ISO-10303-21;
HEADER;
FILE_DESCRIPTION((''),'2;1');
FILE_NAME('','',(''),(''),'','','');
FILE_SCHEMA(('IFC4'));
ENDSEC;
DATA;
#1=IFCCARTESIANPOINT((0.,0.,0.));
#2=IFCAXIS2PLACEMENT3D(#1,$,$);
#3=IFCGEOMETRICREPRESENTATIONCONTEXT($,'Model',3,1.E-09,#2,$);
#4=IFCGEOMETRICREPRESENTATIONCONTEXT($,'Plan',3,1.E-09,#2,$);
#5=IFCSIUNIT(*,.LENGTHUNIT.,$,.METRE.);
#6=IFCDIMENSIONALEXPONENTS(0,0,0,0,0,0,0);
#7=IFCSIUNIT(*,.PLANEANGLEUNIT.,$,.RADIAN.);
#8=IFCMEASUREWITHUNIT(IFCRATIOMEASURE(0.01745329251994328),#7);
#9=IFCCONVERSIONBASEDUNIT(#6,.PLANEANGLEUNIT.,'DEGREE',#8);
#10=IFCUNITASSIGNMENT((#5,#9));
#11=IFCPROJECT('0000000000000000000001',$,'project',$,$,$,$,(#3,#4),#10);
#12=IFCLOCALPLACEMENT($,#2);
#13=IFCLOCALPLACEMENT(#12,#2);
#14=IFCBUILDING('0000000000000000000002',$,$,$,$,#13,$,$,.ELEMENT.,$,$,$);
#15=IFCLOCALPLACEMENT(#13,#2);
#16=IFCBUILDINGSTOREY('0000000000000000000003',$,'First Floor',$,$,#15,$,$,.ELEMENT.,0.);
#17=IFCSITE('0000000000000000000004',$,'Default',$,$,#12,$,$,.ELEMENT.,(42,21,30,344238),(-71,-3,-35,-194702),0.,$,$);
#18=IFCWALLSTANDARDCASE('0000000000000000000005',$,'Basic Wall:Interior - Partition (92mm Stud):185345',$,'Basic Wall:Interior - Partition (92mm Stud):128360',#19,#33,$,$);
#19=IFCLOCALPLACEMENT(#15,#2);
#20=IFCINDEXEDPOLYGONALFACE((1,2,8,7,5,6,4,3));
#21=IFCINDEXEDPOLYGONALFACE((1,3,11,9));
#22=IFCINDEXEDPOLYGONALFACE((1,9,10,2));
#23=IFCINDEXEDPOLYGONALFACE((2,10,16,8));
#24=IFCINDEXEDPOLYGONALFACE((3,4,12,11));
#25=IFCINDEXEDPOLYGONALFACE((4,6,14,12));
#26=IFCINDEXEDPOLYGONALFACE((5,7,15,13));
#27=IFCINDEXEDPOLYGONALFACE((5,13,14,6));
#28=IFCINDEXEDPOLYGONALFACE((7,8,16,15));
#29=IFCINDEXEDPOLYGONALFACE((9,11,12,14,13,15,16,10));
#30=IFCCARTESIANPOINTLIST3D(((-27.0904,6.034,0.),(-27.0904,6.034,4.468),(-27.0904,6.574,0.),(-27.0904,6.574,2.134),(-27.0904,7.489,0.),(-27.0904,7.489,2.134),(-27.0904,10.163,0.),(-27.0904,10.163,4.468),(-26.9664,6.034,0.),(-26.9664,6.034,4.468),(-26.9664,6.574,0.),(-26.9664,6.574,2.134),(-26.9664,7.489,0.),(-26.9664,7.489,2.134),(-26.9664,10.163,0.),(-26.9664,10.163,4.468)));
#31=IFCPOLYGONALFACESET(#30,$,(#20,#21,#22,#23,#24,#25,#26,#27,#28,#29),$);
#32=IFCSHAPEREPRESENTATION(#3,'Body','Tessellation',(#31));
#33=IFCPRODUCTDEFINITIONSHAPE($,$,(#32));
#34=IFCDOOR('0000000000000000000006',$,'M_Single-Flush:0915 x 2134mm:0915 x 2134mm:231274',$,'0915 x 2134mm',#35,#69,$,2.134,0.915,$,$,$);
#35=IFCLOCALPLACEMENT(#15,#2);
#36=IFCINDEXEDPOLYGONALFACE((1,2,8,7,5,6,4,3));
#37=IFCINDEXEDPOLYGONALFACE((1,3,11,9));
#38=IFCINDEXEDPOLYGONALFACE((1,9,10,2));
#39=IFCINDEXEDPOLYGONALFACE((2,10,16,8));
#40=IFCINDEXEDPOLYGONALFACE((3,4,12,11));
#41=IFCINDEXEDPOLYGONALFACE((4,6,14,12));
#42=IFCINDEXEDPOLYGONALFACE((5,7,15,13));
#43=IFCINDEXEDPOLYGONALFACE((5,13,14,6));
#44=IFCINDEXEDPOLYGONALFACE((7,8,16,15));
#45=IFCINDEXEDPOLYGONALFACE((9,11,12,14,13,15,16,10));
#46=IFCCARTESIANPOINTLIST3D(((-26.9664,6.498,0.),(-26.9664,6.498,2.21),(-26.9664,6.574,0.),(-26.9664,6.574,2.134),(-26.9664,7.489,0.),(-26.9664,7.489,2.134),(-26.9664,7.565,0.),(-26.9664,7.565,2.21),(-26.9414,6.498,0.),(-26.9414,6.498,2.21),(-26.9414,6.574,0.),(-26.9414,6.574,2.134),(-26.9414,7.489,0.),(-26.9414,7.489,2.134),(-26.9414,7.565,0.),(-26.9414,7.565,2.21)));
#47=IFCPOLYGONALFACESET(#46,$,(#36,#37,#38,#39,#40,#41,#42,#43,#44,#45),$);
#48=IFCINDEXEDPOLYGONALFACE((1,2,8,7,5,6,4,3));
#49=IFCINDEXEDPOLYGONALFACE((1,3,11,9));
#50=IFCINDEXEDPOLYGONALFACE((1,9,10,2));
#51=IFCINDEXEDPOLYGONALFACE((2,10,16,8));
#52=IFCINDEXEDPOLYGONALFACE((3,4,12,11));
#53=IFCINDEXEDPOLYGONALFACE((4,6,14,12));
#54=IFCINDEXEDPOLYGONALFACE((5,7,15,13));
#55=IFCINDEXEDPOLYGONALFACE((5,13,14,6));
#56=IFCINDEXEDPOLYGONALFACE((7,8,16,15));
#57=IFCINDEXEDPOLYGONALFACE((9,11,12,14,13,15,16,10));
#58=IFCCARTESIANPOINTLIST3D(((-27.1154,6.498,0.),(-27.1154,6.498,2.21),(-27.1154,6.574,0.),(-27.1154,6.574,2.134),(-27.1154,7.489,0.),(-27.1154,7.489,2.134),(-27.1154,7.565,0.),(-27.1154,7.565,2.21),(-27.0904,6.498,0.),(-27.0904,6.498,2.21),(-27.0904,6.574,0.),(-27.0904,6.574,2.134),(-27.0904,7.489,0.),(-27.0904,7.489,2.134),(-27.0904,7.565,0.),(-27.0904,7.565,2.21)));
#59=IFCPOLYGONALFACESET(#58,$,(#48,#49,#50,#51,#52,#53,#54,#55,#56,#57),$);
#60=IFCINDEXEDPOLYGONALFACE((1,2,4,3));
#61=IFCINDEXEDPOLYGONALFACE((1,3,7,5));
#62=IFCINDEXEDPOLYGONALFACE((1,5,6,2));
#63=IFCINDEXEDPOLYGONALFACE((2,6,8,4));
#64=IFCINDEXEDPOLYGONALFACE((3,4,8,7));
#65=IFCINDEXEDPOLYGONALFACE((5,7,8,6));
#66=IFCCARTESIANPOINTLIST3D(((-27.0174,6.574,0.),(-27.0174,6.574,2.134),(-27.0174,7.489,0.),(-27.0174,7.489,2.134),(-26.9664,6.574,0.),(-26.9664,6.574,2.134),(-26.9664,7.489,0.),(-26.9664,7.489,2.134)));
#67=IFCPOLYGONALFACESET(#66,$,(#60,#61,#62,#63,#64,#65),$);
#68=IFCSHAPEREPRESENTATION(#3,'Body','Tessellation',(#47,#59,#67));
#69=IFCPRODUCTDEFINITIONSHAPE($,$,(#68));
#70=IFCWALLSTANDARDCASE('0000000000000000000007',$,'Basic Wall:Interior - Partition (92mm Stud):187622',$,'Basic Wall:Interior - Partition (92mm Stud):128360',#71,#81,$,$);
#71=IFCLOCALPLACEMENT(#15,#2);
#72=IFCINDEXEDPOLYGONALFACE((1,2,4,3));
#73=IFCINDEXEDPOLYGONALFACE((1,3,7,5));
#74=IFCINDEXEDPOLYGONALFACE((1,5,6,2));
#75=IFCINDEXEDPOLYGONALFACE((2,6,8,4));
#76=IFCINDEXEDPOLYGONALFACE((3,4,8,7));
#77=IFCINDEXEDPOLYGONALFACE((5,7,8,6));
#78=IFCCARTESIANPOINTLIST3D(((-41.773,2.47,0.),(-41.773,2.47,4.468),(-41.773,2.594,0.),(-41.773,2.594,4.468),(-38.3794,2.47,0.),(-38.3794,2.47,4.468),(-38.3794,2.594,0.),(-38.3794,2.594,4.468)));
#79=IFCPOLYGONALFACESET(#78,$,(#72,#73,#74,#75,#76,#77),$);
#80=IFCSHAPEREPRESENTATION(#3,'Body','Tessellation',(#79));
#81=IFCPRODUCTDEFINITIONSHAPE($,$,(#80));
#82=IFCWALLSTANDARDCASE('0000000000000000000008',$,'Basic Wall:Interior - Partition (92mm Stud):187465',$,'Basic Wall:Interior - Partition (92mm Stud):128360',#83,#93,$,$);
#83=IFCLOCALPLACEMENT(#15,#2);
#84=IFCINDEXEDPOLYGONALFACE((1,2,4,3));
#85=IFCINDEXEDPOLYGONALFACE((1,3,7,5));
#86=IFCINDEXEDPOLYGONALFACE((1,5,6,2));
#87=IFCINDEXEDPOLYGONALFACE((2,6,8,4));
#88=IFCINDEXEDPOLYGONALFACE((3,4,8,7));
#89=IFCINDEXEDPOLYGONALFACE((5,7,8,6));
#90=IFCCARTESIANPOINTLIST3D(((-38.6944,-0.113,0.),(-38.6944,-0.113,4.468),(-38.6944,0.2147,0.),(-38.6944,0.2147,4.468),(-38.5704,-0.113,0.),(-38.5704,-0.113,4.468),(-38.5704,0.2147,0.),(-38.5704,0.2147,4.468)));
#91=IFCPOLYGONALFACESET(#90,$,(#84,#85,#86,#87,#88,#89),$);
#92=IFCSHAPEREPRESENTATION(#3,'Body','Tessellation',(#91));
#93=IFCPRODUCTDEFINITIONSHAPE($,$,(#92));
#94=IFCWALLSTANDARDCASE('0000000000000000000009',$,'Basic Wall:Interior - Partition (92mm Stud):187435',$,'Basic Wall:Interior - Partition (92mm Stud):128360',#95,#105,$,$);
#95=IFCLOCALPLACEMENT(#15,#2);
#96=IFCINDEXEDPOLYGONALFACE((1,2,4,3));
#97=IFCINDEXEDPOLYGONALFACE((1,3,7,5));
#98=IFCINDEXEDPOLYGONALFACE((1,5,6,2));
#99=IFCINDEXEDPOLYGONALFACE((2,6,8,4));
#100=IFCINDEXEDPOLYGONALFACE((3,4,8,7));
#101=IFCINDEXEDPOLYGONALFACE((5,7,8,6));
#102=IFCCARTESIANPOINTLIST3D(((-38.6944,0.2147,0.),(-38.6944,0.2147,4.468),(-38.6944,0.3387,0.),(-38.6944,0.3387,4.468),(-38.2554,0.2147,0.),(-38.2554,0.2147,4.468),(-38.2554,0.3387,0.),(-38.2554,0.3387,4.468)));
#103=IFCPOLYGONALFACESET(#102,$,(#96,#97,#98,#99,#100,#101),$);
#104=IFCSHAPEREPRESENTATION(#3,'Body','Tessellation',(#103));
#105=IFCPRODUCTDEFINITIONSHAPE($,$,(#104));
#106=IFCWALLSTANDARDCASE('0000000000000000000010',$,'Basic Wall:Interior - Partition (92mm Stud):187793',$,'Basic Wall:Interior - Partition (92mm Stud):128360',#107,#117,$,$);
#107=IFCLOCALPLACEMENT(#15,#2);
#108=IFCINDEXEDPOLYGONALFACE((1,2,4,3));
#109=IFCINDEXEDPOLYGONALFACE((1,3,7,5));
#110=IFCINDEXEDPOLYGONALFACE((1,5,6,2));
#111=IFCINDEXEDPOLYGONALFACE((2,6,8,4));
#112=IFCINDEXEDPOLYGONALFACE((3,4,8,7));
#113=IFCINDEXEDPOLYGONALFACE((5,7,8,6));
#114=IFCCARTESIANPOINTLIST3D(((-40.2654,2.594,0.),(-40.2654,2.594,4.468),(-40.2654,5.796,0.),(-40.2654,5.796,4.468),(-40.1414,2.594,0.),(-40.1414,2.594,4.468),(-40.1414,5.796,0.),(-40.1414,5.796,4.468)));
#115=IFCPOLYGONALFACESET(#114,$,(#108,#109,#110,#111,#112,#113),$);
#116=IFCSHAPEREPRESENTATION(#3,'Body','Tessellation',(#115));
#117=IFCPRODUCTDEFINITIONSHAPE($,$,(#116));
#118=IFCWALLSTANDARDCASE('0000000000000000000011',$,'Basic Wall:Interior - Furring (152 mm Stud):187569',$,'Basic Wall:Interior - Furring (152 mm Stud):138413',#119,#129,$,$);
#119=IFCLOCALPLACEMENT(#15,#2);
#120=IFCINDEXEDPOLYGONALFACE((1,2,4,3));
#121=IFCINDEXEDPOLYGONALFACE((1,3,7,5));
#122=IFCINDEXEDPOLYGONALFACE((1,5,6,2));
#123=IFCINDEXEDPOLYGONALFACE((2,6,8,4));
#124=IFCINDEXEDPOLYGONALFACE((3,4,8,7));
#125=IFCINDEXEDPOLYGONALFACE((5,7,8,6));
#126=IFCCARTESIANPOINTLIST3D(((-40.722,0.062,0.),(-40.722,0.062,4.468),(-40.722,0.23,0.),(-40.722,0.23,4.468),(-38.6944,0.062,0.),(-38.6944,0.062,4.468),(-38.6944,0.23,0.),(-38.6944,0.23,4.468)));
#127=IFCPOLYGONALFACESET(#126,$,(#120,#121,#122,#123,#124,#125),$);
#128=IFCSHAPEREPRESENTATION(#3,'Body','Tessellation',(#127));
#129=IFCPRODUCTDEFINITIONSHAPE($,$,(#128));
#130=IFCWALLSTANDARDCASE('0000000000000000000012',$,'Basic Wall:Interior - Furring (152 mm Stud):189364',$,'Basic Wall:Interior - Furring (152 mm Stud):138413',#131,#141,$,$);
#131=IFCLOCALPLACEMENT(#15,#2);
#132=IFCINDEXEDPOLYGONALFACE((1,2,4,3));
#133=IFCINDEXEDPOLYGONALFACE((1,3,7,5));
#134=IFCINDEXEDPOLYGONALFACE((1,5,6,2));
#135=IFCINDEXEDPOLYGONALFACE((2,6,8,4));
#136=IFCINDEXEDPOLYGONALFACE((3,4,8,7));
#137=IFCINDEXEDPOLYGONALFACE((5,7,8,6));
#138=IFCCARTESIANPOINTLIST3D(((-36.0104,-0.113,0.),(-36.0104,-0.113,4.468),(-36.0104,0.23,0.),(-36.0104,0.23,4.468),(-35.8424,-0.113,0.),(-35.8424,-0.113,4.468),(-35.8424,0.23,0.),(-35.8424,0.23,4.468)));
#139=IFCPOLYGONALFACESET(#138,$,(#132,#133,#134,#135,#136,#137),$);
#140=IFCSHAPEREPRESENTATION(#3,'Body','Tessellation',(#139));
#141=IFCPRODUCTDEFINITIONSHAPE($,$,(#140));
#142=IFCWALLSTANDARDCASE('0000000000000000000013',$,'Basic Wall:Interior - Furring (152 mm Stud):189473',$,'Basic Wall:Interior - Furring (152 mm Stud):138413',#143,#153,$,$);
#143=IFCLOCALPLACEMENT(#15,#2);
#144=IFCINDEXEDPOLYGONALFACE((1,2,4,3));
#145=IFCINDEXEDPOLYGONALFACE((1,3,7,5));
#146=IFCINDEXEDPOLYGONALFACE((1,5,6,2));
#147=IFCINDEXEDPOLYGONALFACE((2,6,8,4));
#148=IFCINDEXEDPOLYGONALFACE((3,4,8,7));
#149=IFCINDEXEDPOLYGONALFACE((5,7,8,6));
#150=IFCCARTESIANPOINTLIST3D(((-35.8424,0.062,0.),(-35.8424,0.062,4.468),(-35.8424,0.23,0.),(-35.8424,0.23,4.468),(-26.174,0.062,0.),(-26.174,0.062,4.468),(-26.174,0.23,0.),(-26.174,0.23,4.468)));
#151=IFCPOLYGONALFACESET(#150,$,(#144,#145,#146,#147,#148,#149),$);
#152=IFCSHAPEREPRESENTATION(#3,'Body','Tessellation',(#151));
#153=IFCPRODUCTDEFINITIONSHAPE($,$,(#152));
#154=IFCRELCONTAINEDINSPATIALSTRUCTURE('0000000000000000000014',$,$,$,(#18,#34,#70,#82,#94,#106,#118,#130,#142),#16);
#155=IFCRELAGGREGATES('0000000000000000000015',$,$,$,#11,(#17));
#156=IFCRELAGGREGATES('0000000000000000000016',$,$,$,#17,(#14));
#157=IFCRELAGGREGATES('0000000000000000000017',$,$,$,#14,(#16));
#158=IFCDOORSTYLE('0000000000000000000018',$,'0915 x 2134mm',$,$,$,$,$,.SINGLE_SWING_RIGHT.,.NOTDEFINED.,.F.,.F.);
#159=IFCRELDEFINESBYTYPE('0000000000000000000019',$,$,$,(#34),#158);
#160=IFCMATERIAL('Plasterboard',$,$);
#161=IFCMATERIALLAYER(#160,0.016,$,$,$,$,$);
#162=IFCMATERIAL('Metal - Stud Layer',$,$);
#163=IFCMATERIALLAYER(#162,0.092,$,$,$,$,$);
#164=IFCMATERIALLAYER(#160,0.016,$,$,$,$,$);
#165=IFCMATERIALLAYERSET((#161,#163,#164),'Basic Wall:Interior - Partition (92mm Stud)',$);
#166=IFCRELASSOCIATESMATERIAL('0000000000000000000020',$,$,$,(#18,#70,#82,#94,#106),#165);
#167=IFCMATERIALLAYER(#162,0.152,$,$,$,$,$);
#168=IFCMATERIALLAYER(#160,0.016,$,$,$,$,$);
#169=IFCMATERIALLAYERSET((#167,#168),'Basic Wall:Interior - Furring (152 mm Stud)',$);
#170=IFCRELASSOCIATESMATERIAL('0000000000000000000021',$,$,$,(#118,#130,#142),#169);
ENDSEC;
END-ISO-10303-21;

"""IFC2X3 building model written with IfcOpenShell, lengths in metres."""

from ifc_helpers import new_model, entity, si_unit, converted_unit, frame, frame_2d, origin, origin_2d_with_axis, place, context, project, spatial, polyline, rectangle, outline, extrude, source, transform, mapped, material, layer, layer_set, layer_usage, type_object, type_shapes, element, fill, save


model = new_model("IFC2X3")

# Units and contexts
model_context = context("Model", 3, precision=1e-09, world=origin())
plan_context = context("Plan", 3, precision=1e-09, world=origin())
ifc_project = project(units=[si_unit("LENGTHUNIT", "METRE"), converted_unit("PLANEANGLEUNIT", "DEGREE", entity("IfcRatioMeasure", 0.01745329251994328), si_unit("PLANEANGLEUNIT", "RADIAN"), dimensions=[0, 0, 0, 0, 0, 0, 0])], contexts=[model_context, plan_context])

# Site, building, storey
site_placement = place(None, origin())
site = spatial("IfcSite", under=ifc_project, at=site_placement, Name="Default", CompositionType="ELEMENT", RefLatitude=(42, 21, 30, 344238), RefLongitude=(-71, -3, -35, -194702), RefElevation=0.0)
building_placement = place(site_placement, origin())
building = spatial("IfcBuilding", under=site, at=building_placement, CompositionType="ELEMENT")
storey_placement = place(building_placement, origin())
storey = spatial("IfcBuildingStorey", under=building, at=storey_placement, Name="First Floor", CompositionType="ELEMENT", Elevation=0.0)

# Wall, opening, door
ifc_material_1 = material(Name="Plasterboard")
ifc_layer_1 = layer(ifc_material_1, 0.016)
ifc_material_2 = material(Name="Metal - Stud Layer")
ifc_layer_2 = layer(ifc_material_2, 0.092)
ifc_layer_3 = layer(ifc_material_1, 0.016)
ifc_layer_set_1 = layer_set([ifc_layer_1, ifc_layer_2, ifc_layer_3], Name="Basic Wall:Interior - Partition (92mm Stud)")
ifc_layer_usage_1 = layer_usage(ifc_layer_set_1, "AXIS2", "NEGATIVE", 0.062)
wall_1_placement = place(storey_placement, frame((-27.0284, 6.034, 0.0), z_axis=(0.0, 0.0, 1.0), x_axis=(0.0, 1.0, 0.0)))
wall_1 = element("IfcWallStandardCase", 1, at=wall_1_placement, inside=storey, material=ifc_layer_usage_1, Name="Basic Wall:Interior - Partition (92mm Stud):185345", ObjectType="Basic Wall:Interior - Partition (92mm Stud):128360", context=model_context, shape_type="SweptSolid", body=[
    extrude(rectangle(XDim=4.129, YDim=0.124, at=frame_2d((2.0645, 0.0), x_axis=(-1.0, 0.0))), origin(), (0.0, 0.0, 1.0), 4.468),
])
opening_1_placement = place(wall_1_placement, frame((1.455, 0.062, 0.0)))
opening_1 = element("IfcOpeningElement", 2, at=opening_1_placement, cuts=wall_1, ObjectType="Opening", context=model_context, shape_type="SweptSolid", body=[
    extrude(rectangle(XDim=0.915, YDim=2.134, at=frame_2d((1.067, 0.4575), x_axis=(0.0, 1.0))), frame((0.0, 0.0, 0.0), z_axis=(0.0, -1.0, 0.0), x_axis=(0.0, 0.0, 1.0)), (0.0, 0.0, 1.0), 0.124),
])
door_style = type_object("IfcDoorStyle", Name="0915 x 2134mm", ConstructionType="NOTDEFINED", OperationType="SINGLE_SWING_RIGHT", ParameterTakesPrecedence=False, Sizeable=False)
shared_shape_1 = source(origin(), model_context, "Body", "SweptSolid", [
    extrude(outline(polyline([(-0.5335, -1.124), (0.5335, -1.124), (0.5335, 1.086), (0.4575, 1.086), (0.4575, -1.048), (-0.4575, -1.048), (-0.4575, 1.086), (-0.5335, 1.086), (-0.5335, -1.124)])), frame((0.4575, 0.124, 1.086), z_axis=(0.0, 1.0, 0.0), x_axis=(1.0, 0.0, 0.0)), (0.0, 0.0, 1.0), 0.025),
    extrude(outline(polyline([(-1.124, -0.5335), (1.086, -0.5335), (1.086, -0.4575), (-1.048, -0.4575), (-1.048, 0.4575), (1.086, 0.4575), (1.086, 0.5335), (-1.124, 0.5335), (-1.124, -0.5335)])), frame((0.4575, -0.025, 1.086), z_axis=(0.0, 1.0, 0.0), x_axis=(0.0, 0.0, -1.0)), (0.0, 0.0, 1.0), 0.025),
    extrude(rectangle(XDim=0.051, YDim=0.915, at=origin_2d_with_axis()), frame((0.4575, 0.0985, 0.0), z_axis=(0.0, 0.0, 1.0), x_axis=(0.0, 1.0, 0.0)), (0.0, 0.0, 1.0), 2.134),
])
type_shapes(door_style, [shared_shape_1])
door_placement = place(opening_1_placement, frame((0.0, 0.0, 0.0), z_axis=(0.0, 0.0, 1.0), x_axis=(-1.0, 0.0, 0.0)))
door = element("IfcDoor", 3, at=door_placement, inside=storey, type_object=door_style, Name="M_Single-Flush:0915 x 2134mm:0915 x 2134mm:231274", ObjectType="0915 x 2134mm", OverallHeight=2.134, OverallWidth=0.915, context=model_context, shape_type="MappedRepresentation", body=[
    mapped(shared_shape_1, transform((0.0, 0.0, 0.0), scale=1.0)),
])
fill(opening_1, door)

# Walls
wall_2_placement = place(storey_placement, frame((-38.3794, 2.532, 0.0), z_axis=(0.0, 0.0, 1.0), x_axis=(-1.0, 0.0, 0.0)))
element("IfcWallStandardCase", 4, at=wall_2_placement, inside=storey, material=ifc_layer_usage_1, Name="Basic Wall:Interior - Partition (92mm Stud):187622", ObjectType="Basic Wall:Interior - Partition (92mm Stud):128360", context=model_context, shape_type="SweptSolid", body=[
    extrude(rectangle(XDim=3.3936, YDim=0.124, at=frame_2d((1.6968, 0.0), x_axis=(-1.0, 0.0))), origin(), (0.0, 0.0, 1.0), 4.468),
])
wall_3_placement = place(storey_placement, frame((-38.6324, 0.2147, 0.0), z_axis=(0.0, 0.0, 1.0), x_axis=(0.0, -1.0, 0.0)))
element("IfcWallStandardCase", 5, at=wall_3_placement, inside=storey, material=ifc_layer_usage_1, Name="Basic Wall:Interior - Partition (92mm Stud):187465", ObjectType="Basic Wall:Interior - Partition (92mm Stud):128360", context=model_context, shape_type="SweptSolid", body=[
    extrude(rectangle(XDim=0.3277, YDim=0.124, at=frame_2d((0.1639, 0.0), x_axis=(-1.0, 0.0))), origin(), (0.0, 0.0, 1.0), 4.468),
])
wall_4_placement = place(storey_placement, frame((-38.2554, 0.2767, 0.0), z_axis=(0.0, 0.0, 1.0), x_axis=(-1.0, 0.0, 0.0)))
element("IfcWallStandardCase", 6, at=wall_4_placement, inside=storey, material=ifc_layer_usage_1, Name="Basic Wall:Interior - Partition (92mm Stud):187435", ObjectType="Basic Wall:Interior - Partition (92mm Stud):128360", context=model_context, shape_type="SweptSolid", body=[
    extrude(rectangle(XDim=0.439, YDim=0.124, at=frame_2d((0.2195, 0.0), x_axis=(-1.0, 0.0))), origin(), (0.0, 0.0, 1.0), 4.468),
])
wall_5_placement = place(storey_placement, frame((-40.2034, 2.594, 0.0), z_axis=(0.0, 0.0, 1.0), x_axis=(0.0, 1.0, 0.0)))
element("IfcWallStandardCase", 7, at=wall_5_placement, inside=storey, material=ifc_layer_usage_1, Name="Basic Wall:Interior - Partition (92mm Stud):187793", ObjectType="Basic Wall:Interior - Partition (92mm Stud):128360", context=model_context, shape_type="SweptSolid", body=[
    extrude(rectangle(XDim=3.202, YDim=0.124, at=frame_2d((1.601, 0.0), x_axis=(-1.0, 0.0))), origin(), (0.0, 0.0, 1.0), 4.468),
])
ifc_layer_4 = layer(ifc_material_2, 0.152)
ifc_layer_5 = layer(ifc_material_1, 0.016)
ifc_layer_set_2 = layer_set([ifc_layer_4, ifc_layer_5], Name="Basic Wall:Interior - Furring (152 mm Stud)")
ifc_layer_usage_2 = layer_usage(ifc_layer_set_2, "AXIS2", "POSITIVE", -0.084)
wall_6_placement = place(storey_placement, frame((-40.722, 0.146, 0.0)))
element("IfcWallStandardCase", 8, at=wall_6_placement, inside=storey, material=ifc_layer_usage_2, Name="Basic Wall:Interior - Furring (152 mm Stud):187569", ObjectType="Basic Wall:Interior - Furring (152 mm Stud):138413", context=model_context, shape_type="SweptSolid", body=[
    extrude(rectangle(XDim=2.0276, YDim=0.168, at=frame_2d((1.0138, 0.0), x_axis=(-1.0, 0.0))), origin(), (0.0, 0.0, 1.0), 4.468),
])
wall_7_placement = place(storey_placement, frame((-35.9264, -0.113, 0.0), z_axis=(0.0, 0.0, 1.0), x_axis=(0.0, 1.0, 0.0)))
element("IfcWallStandardCase", 9, at=wall_7_placement, inside=storey, material=ifc_layer_usage_2, Name="Basic Wall:Interior - Furring (152 mm Stud):189364", ObjectType="Basic Wall:Interior - Furring (152 mm Stud):138413", context=model_context, shape_type="SweptSolid", body=[
    extrude(rectangle(XDim=0.343, YDim=0.168, at=frame_2d((0.1715, 0.0), x_axis=(-1.0, 0.0))), origin(), (0.0, 0.0, 1.0), 4.468),
])
wall_8_placement = place(storey_placement, frame((-35.8424, 0.146, 0.0)))
element("IfcWallStandardCase", 10, at=wall_8_placement, inside=storey, material=ifc_layer_usage_2, Name="Basic Wall:Interior - Furring (152 mm Stud):189473", ObjectType="Basic Wall:Interior - Furring (152 mm Stud):138413", context=model_context, shape_type="SweptSolid", body=[
    extrude(rectangle(XDim=9.6684, YDim=0.168, at=frame_2d((4.8342, 0.0), x_axis=(-1.0, 0.0))), origin(), (0.0, 0.0, 1.0), 4.468),
])

save(model, "model.ifc")
